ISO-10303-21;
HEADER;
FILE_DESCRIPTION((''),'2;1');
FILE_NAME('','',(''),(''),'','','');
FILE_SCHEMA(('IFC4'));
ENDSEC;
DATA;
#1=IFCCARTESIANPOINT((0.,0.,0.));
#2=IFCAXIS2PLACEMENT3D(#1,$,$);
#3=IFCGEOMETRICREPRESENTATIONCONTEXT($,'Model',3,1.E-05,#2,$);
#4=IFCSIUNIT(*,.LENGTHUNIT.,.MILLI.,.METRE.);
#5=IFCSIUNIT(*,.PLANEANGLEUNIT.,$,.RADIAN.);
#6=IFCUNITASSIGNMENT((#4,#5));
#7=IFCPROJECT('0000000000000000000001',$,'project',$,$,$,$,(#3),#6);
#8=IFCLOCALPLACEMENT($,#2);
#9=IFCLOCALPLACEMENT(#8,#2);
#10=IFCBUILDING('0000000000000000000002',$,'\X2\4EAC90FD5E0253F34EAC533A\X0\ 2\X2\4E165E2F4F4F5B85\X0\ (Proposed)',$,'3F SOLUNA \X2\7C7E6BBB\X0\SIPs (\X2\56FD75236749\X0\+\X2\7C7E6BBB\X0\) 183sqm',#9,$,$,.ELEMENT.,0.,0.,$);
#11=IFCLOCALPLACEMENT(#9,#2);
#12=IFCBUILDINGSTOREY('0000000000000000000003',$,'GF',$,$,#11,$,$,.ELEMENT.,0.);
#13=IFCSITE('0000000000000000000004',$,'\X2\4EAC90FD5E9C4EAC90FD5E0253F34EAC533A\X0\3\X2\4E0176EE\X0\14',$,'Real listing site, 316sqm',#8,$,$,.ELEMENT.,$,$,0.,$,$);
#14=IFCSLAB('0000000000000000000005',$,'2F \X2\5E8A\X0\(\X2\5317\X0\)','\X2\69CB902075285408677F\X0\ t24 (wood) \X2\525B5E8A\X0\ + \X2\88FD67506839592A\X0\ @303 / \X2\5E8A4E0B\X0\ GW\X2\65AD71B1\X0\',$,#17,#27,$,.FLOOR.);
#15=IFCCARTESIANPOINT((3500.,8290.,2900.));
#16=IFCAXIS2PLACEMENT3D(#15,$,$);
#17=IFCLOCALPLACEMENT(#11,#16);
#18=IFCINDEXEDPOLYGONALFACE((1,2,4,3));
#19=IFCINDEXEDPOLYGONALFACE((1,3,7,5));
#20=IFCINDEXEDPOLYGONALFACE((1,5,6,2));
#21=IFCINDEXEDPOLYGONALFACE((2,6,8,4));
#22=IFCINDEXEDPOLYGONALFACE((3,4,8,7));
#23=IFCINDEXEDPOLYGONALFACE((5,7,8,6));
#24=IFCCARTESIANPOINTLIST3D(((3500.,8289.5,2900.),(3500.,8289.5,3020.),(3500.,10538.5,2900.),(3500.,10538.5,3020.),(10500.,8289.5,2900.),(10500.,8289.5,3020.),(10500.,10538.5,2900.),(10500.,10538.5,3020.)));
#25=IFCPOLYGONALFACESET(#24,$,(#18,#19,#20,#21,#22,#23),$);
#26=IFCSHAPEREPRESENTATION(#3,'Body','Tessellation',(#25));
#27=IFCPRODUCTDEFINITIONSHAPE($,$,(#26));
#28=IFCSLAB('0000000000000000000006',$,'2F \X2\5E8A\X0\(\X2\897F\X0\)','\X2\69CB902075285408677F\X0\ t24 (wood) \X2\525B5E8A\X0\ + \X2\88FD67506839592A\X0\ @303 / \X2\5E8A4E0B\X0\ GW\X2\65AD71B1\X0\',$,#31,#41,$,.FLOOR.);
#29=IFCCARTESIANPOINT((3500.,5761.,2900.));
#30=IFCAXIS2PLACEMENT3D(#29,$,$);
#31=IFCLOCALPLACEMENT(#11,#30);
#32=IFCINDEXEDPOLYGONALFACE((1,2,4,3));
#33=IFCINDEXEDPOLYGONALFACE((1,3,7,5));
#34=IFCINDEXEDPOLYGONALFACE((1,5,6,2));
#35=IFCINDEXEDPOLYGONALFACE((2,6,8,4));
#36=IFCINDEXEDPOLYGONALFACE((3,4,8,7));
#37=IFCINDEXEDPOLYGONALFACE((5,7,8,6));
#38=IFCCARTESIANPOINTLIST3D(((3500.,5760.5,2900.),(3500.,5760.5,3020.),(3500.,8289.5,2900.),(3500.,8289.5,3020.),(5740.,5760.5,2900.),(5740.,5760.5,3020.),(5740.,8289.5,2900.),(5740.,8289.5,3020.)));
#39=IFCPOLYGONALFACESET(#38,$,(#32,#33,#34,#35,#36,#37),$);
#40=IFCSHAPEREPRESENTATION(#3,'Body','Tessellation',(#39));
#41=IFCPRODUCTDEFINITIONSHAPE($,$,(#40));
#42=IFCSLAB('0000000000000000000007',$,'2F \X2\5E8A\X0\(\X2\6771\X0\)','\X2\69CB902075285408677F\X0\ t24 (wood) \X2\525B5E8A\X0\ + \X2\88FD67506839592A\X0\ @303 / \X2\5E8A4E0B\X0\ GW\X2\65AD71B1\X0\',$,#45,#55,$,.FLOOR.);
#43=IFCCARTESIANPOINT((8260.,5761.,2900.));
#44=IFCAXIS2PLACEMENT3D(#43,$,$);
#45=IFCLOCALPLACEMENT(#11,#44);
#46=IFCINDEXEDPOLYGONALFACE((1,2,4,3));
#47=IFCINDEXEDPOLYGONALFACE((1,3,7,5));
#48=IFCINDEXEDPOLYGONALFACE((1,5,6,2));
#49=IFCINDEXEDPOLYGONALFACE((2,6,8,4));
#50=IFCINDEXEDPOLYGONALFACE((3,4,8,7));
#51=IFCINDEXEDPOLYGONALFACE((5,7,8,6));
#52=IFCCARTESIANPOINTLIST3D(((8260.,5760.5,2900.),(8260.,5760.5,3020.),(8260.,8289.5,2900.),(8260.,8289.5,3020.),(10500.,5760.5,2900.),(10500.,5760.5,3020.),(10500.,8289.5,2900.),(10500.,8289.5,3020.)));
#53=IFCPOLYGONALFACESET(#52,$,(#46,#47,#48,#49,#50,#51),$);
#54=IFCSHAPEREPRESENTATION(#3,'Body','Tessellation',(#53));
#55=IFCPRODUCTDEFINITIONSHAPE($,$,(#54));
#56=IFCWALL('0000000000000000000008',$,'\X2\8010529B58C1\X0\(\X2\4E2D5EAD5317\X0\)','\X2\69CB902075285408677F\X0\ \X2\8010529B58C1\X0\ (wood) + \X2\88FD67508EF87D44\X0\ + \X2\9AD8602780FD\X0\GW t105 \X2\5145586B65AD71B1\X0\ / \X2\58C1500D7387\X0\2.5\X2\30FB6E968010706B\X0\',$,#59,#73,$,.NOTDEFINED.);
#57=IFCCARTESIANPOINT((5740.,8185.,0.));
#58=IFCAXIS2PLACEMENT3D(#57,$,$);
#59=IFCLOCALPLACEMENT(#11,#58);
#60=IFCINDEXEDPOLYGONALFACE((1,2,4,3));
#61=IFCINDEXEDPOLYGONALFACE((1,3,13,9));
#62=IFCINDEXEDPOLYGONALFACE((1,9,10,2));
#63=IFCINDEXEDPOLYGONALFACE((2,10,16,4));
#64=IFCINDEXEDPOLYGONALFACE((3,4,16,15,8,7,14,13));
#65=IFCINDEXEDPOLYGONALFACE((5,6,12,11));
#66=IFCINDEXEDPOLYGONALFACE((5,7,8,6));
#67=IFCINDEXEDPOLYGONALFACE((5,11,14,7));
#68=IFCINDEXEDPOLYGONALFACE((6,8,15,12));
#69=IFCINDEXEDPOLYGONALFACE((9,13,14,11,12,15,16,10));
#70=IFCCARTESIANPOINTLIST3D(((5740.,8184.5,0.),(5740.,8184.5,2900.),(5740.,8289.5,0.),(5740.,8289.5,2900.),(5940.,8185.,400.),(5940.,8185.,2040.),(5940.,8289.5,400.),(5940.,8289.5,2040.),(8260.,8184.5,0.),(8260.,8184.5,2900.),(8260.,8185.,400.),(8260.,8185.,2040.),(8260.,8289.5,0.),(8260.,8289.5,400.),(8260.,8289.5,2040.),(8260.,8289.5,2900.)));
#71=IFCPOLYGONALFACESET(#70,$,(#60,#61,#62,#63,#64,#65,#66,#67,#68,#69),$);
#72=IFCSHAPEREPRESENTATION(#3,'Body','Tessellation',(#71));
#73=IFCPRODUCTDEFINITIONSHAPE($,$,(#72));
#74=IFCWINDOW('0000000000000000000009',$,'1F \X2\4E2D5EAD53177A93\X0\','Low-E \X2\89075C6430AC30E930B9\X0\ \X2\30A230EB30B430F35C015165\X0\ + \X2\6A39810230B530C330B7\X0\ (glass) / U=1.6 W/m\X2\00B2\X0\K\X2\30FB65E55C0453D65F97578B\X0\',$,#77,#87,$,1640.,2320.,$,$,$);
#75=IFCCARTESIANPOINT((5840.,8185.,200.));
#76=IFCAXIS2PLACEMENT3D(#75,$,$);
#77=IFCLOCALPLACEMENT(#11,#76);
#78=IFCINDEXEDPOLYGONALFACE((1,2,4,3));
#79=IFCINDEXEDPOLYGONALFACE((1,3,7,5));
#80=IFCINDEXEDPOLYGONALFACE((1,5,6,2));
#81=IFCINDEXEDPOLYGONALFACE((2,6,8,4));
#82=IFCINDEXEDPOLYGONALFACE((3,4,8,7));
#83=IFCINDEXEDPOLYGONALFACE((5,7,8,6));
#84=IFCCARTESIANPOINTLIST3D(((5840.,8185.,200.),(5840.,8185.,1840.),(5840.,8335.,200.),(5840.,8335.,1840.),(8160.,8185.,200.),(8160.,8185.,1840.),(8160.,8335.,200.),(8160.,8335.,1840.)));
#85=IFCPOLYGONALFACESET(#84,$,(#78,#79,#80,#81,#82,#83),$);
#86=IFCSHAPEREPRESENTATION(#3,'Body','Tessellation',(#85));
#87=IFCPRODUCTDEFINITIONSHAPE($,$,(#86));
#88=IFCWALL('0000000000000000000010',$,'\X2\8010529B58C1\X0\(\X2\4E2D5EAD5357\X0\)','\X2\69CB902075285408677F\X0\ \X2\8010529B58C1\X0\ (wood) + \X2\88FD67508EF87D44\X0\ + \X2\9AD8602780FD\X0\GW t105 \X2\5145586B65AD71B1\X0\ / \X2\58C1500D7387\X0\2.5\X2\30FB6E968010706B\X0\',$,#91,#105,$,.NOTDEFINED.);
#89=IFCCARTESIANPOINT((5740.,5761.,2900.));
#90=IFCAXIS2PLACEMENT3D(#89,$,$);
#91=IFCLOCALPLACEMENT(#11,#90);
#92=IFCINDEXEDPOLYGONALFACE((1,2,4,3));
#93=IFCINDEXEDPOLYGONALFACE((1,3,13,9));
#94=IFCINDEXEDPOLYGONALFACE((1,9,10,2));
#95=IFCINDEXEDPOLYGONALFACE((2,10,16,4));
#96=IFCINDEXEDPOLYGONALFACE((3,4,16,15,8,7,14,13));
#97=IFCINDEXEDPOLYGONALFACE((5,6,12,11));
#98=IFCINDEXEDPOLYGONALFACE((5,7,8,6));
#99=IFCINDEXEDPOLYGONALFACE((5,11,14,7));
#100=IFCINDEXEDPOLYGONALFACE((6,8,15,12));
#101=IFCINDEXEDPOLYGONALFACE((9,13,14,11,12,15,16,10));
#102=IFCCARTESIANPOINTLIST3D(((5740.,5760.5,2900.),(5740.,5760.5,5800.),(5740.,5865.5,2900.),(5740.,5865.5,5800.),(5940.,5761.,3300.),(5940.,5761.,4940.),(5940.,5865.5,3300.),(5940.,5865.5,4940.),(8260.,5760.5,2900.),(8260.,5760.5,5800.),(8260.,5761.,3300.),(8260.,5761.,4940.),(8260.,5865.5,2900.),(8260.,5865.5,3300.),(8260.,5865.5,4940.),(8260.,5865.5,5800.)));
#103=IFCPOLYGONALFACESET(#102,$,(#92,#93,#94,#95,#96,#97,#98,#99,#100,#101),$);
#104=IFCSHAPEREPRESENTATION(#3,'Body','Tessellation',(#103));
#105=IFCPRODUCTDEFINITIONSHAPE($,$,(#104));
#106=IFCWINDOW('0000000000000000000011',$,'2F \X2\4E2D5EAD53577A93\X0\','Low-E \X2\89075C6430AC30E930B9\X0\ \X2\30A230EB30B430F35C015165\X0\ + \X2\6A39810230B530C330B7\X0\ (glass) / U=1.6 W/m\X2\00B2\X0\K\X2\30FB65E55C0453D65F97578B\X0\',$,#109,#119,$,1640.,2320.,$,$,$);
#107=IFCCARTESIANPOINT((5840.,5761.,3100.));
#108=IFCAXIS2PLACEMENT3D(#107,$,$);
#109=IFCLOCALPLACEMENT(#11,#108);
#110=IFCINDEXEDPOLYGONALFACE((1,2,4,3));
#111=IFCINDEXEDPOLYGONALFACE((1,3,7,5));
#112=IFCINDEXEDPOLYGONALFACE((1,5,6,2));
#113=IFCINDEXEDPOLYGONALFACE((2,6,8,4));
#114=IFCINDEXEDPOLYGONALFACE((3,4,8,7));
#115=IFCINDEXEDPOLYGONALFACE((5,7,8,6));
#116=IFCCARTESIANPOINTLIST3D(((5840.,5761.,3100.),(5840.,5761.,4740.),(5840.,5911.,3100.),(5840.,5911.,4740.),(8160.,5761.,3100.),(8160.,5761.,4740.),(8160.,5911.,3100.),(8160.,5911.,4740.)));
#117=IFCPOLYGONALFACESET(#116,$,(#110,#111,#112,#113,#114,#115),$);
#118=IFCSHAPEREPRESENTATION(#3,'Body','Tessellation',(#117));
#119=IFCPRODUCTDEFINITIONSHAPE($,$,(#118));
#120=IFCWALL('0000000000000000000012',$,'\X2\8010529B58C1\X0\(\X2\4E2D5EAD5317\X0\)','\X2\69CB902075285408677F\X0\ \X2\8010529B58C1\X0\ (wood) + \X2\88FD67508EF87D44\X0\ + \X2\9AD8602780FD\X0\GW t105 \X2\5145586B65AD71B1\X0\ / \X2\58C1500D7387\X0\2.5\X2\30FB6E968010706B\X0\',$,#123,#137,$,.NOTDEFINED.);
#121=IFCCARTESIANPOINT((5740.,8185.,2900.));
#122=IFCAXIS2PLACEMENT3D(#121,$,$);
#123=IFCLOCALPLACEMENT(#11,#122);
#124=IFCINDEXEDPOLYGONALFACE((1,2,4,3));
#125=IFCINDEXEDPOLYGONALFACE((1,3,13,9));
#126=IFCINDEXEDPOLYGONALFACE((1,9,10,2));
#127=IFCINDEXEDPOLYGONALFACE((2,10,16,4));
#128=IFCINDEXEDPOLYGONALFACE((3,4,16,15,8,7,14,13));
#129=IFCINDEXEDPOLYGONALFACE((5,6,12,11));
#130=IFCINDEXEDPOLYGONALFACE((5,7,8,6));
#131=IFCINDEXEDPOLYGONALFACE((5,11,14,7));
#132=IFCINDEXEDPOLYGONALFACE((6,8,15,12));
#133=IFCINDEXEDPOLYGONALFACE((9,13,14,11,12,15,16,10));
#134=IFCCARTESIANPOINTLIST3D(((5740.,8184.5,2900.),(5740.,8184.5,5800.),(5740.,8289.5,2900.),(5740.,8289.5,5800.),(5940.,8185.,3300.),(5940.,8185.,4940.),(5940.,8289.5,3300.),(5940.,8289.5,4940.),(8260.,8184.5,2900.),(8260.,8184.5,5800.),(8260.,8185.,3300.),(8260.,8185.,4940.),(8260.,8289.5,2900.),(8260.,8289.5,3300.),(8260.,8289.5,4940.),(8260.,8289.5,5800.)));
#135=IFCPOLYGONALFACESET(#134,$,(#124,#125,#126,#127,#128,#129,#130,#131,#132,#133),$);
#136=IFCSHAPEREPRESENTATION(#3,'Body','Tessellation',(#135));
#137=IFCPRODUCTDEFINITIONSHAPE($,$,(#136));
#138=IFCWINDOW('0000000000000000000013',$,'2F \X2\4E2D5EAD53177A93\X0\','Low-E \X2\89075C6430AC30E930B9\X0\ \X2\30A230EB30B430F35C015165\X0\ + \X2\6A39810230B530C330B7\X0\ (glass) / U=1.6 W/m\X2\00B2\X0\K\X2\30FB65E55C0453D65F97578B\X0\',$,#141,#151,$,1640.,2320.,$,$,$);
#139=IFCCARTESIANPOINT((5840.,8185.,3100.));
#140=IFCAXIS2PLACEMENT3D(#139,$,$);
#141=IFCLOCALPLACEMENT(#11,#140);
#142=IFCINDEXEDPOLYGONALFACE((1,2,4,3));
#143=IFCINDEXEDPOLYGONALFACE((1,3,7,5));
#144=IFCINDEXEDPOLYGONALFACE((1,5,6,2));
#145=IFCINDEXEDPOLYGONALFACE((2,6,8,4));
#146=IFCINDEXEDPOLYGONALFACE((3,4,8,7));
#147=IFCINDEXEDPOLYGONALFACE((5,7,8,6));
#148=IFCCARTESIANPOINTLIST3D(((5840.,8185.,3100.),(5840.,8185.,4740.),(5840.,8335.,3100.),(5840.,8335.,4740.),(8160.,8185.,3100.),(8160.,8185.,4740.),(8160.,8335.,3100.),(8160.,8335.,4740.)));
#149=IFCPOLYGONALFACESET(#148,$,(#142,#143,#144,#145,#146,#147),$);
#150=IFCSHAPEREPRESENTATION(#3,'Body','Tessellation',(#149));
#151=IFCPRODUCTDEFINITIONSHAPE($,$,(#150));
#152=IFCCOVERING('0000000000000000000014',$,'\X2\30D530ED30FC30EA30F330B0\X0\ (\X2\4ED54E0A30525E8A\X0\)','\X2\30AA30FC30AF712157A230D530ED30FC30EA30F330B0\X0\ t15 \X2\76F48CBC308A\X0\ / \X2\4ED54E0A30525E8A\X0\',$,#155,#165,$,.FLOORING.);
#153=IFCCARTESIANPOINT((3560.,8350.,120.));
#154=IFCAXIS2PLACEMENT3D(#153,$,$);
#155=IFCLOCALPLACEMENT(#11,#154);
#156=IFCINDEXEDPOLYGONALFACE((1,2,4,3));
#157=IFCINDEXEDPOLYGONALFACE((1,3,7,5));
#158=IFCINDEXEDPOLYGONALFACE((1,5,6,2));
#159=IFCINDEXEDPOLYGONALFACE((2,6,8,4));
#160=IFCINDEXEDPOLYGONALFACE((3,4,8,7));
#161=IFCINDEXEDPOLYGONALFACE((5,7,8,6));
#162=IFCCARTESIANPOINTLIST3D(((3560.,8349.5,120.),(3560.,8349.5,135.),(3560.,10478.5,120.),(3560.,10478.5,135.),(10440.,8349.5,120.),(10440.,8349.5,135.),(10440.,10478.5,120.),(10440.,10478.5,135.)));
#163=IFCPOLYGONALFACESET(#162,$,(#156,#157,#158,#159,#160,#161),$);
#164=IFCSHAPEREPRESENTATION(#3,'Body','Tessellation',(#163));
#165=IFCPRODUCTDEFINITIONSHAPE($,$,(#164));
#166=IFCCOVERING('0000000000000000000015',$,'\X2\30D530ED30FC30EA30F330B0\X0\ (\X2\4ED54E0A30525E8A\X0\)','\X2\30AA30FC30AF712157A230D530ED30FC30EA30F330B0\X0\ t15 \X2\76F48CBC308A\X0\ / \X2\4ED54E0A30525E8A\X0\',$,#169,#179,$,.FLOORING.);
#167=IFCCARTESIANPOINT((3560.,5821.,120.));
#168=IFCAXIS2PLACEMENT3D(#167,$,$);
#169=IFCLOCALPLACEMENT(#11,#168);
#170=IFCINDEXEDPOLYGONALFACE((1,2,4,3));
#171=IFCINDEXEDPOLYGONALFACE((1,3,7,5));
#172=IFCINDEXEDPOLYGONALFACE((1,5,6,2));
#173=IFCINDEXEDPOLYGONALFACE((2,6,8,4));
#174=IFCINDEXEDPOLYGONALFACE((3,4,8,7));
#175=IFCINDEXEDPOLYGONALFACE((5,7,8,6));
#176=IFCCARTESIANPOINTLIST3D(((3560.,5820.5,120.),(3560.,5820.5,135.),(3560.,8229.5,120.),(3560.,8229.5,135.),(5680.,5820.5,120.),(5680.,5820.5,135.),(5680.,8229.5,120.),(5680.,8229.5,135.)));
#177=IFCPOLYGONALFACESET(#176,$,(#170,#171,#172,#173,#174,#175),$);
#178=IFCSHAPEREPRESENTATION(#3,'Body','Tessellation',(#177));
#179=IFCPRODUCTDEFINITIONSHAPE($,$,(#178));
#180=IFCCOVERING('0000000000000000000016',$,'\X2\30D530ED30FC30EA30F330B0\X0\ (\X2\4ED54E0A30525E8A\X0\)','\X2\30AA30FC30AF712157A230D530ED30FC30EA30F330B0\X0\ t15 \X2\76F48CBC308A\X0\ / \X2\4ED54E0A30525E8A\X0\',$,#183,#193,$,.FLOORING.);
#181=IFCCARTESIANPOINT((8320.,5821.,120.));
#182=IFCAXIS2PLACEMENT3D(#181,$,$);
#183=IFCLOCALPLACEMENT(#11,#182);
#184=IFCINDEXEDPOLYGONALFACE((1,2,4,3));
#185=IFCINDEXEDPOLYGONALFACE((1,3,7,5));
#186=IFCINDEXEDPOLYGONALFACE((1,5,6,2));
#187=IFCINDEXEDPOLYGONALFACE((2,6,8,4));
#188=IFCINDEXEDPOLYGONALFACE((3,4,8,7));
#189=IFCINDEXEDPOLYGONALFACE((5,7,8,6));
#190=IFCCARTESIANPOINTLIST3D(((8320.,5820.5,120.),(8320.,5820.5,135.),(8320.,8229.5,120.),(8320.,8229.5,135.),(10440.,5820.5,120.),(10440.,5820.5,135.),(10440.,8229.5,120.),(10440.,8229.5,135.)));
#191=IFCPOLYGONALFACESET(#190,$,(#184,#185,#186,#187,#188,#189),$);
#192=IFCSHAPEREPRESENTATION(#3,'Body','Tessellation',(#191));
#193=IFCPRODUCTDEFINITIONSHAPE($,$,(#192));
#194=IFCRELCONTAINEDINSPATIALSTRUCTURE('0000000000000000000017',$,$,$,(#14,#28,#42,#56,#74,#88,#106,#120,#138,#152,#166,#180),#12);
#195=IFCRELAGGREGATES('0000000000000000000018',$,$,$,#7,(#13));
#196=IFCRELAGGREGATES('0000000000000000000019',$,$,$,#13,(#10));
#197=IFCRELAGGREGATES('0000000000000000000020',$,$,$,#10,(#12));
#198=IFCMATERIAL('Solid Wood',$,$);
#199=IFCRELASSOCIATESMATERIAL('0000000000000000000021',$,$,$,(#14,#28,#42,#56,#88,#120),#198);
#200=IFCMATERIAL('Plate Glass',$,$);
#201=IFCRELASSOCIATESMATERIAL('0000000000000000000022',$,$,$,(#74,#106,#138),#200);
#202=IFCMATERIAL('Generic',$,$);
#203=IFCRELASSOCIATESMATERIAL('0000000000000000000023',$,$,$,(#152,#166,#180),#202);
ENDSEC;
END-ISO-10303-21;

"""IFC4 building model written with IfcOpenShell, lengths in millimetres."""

from ifc_helpers import new_model, si_unit, frame, frame_2d, origin, place, context, project, spatial, rectangle, extrude, material, element, fill, save


model = new_model("IFC4")

# Units and contexts
model_context = context("Model", 3, precision=1e-05, world=origin())
ifc_project = project(units=[si_unit("LENGTHUNIT", "METRE", prefix="MILLI"), si_unit("PLANEANGLEUNIT", "RADIAN")], contexts=[model_context])

# Site, building, storey
site_placement = place(None, origin())
site = spatial("IfcSite", under=ifc_project, at=site_placement, Name="京都府京都市右京区3丁目14", ObjectType="Real listing site, 316sqm", CompositionType="ELEMENT", RefElevation=0.0)
building_placement = place(site_placement, origin())
building = spatial("IfcBuilding", under=site, at=building_placement, Name="京都市右京区 2世帯住宅 (Proposed)", ObjectType="3F SOLUNA 籾殻SIPs (国産杉+籾殻) 183sqm", CompositionType="ELEMENT", ElevationOfRefHeight=0.0, ElevationOfTerrain=0.0)
storey_placement = place(building_placement, origin())
storey = spatial("IfcBuildingStorey", under=building, at=storey_placement, Name="GF", CompositionType="ELEMENT", Elevation=0.0)

# Slabs
ifc_material_1 = material(Name="Solid Wood")
slab_1_placement = place(storey_placement, frame((3500.0, 8290.0, 2900.0)))
element("IfcSlab", 1, at=slab_1_placement, inside=storey, material=ifc_material_1, Name="2F 床(北)", Description="構造用合板 t24 (wood) 剛床 + 製材根太 @303 / 床下 GW断熱", PredefinedType="FLOOR", context=model_context, shape_type="SweptSolid", body=[
    extrude(rectangle(XDim=7000.0, YDim=2249.0, at=frame_2d((3500.0, 1124.0))), frame((3500.0, 8290.0, 2900.0)), (0.0, 0.0, 1.0), 120.0),
])
slab_2_placement = place(storey_placement, frame((3500.0, 5761.0, 2900.0)))
element("IfcSlab", 2, at=slab_2_placement, inside=storey, material=ifc_material_1, Name="2F 床(西)", Description="構造用合板 t24 (wood) 剛床 + 製材根太 @303 / 床下 GW断熱", PredefinedType="FLOOR", context=model_context, shape_type="SweptSolid", body=[
    extrude(rectangle(XDim=2240.0, YDim=2529.0, at=frame_2d((1120.0, 1264.0))), frame((3500.0, 5761.0, 2900.0)), (0.0, 0.0, 1.0), 120.0),
])
slab_3_placement = place(storey_placement, frame((8260.0, 5761.0, 2900.0)))
element("IfcSlab", 3, at=slab_3_placement, inside=storey, material=ifc_material_1, Name="2F 床(東)", Description="構造用合板 t24 (wood) 剛床 + 製材根太 @303 / 床下 GW断熱", PredefinedType="FLOOR", context=model_context, shape_type="SweptSolid", body=[
    extrude(rectangle(XDim=2240.0, YDim=2529.0, at=frame_2d((1120.0, 1264.0))), frame((8260.0, 5761.0, 2900.0)), (0.0, 0.0, 1.0), 120.0),
])

# Wall, opening, window
wall_1_placement = place(storey_placement, frame((5740.0, 8185.0, 0.0)))
wall_1 = element("IfcWall", 4, at=wall_1_placement, inside=storey, material=ifc_material_1, Name="耐力壁(中庭北)", Description="構造用合板 耐力壁 (wood) + 製材軸組 + 高性能GW t105 充填断熱 / 壁倍率2.5・準耐火", PredefinedType="NOTDEFINED", context=model_context, shape_type="SweptSolid", body=[
    extrude(rectangle(XDim=2520.0, YDim=105.0, at=frame_2d((1260.0, 52.0))), frame((5740.0, 8185.0, 0.0)), (0.0, 0.0, 1.0), 2900.0),
])
opening_1_placement = place(storey_placement, frame((5840.0, 8185.0, 200.0)))
opening_1 = element("IfcOpeningElement", 5, at=opening_1_placement, cuts=wall_1, PredefinedType="NOTDEFINED", context=model_context, shape_type="SweptSolid", body=[
    extrude(rectangle(XDim=2320.0, YDim=150.0, at=frame_2d((1160.0, 75.0))), frame((5840.0, 8185.0, 200.0)), (0.0, 0.0, 1.0), 1640.0),
])
ifc_material_2 = material(Name="Plate Glass")
window_1_placement = place(storey_placement, frame((5840.0, 8185.0, 200.0)))
window_1 = element("IfcWindow", 6, at=window_1_placement, inside=storey, material=ifc_material_2, Name="1F 中庭北窓", Description="Low-E 複層ガラス アルゴン封入 + 樹脂サッシ (glass) / U=1.6 W/m²K・日射取得型", OverallHeight=1640.0, OverallWidth=2320.0, context=model_context, shape_type="SweptSolid", body=[
    extrude(rectangle(XDim=2320.0, YDim=150.0, at=frame_2d((1160.0, 75.0))), frame((5840.0, 8185.0, 200.0)), (0.0, 0.0, 1.0), 1640.0),
])
fill(opening_1, window_1)

# Walls, openings, windows
wall_2_placement = place(storey_placement, frame((5740.0, 5761.0, 2900.0)))
wall_2 = element("IfcWall", 7, at=wall_2_placement, inside=storey, material=ifc_material_1, Name="耐力壁(中庭南)", Description="構造用合板 耐力壁 (wood) + 製材軸組 + 高性能GW t105 充填断熱 / 壁倍率2.5・準耐火", PredefinedType="NOTDEFINED", context=model_context, shape_type="SweptSolid", body=[
    extrude(rectangle(XDim=2520.0, YDim=105.0, at=frame_2d((1260.0, 52.0))), frame((5740.0, 5761.0, 2900.0)), (0.0, 0.0, 1.0), 2900.0),
])
opening_2_placement = place(storey_placement, frame((5840.0, 5761.0, 3100.0)))
opening_2 = element("IfcOpeningElement", 8, at=opening_2_placement, cuts=wall_2, PredefinedType="NOTDEFINED", context=model_context, shape_type="SweptSolid", body=[
    extrude(rectangle(XDim=2320.0, YDim=150.0, at=frame_2d((1160.0, 75.0))), frame((5840.0, 5761.0, 3100.0)), (0.0, 0.0, 1.0), 1640.0),
])
window_2_placement = place(storey_placement, frame((5840.0, 5761.0, 3100.0)))
window_2 = element("IfcWindow", 9, at=window_2_placement, inside=storey, material=ifc_material_2, Name="2F 中庭南窓", Description="Low-E 複層ガラス アルゴン封入 + 樹脂サッシ (glass) / U=1.6 W/m²K・日射取得型", OverallHeight=1640.0, OverallWidth=2320.0, context=model_context, shape_type="SweptSolid", body=[
    extrude(rectangle(XDim=2320.0, YDim=150.0, at=frame_2d((1160.0, 75.0))), frame((5840.0, 5761.0, 3100.0)), (0.0, 0.0, 1.0), 1640.0),
])
fill(opening_2, window_2)
wall_3_placement = place(storey_placement, frame((5740.0, 8185.0, 2900.0)))
wall_3 = element("IfcWall", 10, at=wall_3_placement, inside=storey, material=ifc_material_1, Name="耐力壁(中庭北)", Description="構造用合板 耐力壁 (wood) + 製材軸組 + 高性能GW t105 充填断熱 / 壁倍率2.5・準耐火", PredefinedType="NOTDEFINED", context=model_context, shape_type="SweptSolid", body=[
    extrude(rectangle(XDim=2520.0, YDim=105.0, at=frame_2d((1260.0, 52.0))), frame((5740.0, 8185.0, 2900.0)), (0.0, 0.0, 1.0), 2900.0),
])
opening_3_placement = place(storey_placement, frame((5840.0, 8185.0, 3100.0)))
opening_3 = element("IfcOpeningElement", 11, at=opening_3_placement, cuts=wall_3, PredefinedType="NOTDEFINED", context=model_context, shape_type="SweptSolid", body=[
    extrude(rectangle(XDim=2320.0, YDim=150.0, at=frame_2d((1160.0, 75.0))), frame((5840.0, 8185.0, 3100.0)), (0.0, 0.0, 1.0), 1640.0),
])
window_3_placement = place(storey_placement, frame((5840.0, 8185.0, 3100.0)))
window_3 = element("IfcWindow", 12, at=window_3_placement, inside=storey, material=ifc_material_2, Name="2F 中庭北窓", Description="Low-E 複層ガラス アルゴン封入 + 樹脂サッシ (glass) / U=1.6 W/m²K・日射取得型", OverallHeight=1640.0, OverallWidth=2320.0, context=model_context, shape_type="SweptSolid", body=[
    extrude(rectangle(XDim=2320.0, YDim=150.0, at=frame_2d((1160.0, 75.0))), frame((5840.0, 8185.0, 3100.0)), (0.0, 0.0, 1.0), 1640.0),
])
fill(opening_3, window_3)

# Coverings
ifc_material_3 = material(Name="Generic")
covering_1_placement = place(storey_placement, frame((3560.0, 8350.0, 120.0)))
element("IfcCovering", 13, at=covering_1_placement, inside=storey, material=ifc_material_3, Name="フローリング (仕上げ床)", Description="オーク無垢フローリング t15 直貼り / 仕上げ床", PredefinedType="FLOORING", context=model_context, shape_type="SweptSolid", body=[
    extrude(rectangle(XDim=6880.0, YDim=2129.0, at=frame_2d((3440.0, 1064.0))), frame((3560.0, 8350.0, 120.0)), (0.0, 0.0, 1.0), 15.0),
])
covering_2_placement = place(storey_placement, frame((3560.0, 5821.0, 120.0)))
element("IfcCovering", 14, at=covering_2_placement, inside=storey, material=ifc_material_3, Name="フローリング (仕上げ床)", Description="オーク無垢フローリング t15 直貼り / 仕上げ床", PredefinedType="FLOORING", context=model_context, shape_type="SweptSolid", body=[
    extrude(rectangle(XDim=2120.0, YDim=2409.0, at=frame_2d((1060.0, 1204.0))), frame((3560.0, 5821.0, 120.0)), (0.0, 0.0, 1.0), 15.0),
])
covering_3_placement = place(storey_placement, frame((8320.0, 5821.0, 120.0)))
element("IfcCovering", 15, at=covering_3_placement, inside=storey, material=ifc_material_3, Name="フローリング (仕上げ床)", Description="オーク無垢フローリング t15 直貼り / 仕上げ床", PredefinedType="FLOORING", context=model_context, shape_type="SweptSolid", body=[
    extrude(rectangle(XDim=2120.0, YDim=2409.0, at=frame_2d((1060.0, 1204.0))), frame((8320.0, 5821.0, 120.0)), (0.0, 0.0, 1.0), 15.0),
])

save(model, "model.ifc")
